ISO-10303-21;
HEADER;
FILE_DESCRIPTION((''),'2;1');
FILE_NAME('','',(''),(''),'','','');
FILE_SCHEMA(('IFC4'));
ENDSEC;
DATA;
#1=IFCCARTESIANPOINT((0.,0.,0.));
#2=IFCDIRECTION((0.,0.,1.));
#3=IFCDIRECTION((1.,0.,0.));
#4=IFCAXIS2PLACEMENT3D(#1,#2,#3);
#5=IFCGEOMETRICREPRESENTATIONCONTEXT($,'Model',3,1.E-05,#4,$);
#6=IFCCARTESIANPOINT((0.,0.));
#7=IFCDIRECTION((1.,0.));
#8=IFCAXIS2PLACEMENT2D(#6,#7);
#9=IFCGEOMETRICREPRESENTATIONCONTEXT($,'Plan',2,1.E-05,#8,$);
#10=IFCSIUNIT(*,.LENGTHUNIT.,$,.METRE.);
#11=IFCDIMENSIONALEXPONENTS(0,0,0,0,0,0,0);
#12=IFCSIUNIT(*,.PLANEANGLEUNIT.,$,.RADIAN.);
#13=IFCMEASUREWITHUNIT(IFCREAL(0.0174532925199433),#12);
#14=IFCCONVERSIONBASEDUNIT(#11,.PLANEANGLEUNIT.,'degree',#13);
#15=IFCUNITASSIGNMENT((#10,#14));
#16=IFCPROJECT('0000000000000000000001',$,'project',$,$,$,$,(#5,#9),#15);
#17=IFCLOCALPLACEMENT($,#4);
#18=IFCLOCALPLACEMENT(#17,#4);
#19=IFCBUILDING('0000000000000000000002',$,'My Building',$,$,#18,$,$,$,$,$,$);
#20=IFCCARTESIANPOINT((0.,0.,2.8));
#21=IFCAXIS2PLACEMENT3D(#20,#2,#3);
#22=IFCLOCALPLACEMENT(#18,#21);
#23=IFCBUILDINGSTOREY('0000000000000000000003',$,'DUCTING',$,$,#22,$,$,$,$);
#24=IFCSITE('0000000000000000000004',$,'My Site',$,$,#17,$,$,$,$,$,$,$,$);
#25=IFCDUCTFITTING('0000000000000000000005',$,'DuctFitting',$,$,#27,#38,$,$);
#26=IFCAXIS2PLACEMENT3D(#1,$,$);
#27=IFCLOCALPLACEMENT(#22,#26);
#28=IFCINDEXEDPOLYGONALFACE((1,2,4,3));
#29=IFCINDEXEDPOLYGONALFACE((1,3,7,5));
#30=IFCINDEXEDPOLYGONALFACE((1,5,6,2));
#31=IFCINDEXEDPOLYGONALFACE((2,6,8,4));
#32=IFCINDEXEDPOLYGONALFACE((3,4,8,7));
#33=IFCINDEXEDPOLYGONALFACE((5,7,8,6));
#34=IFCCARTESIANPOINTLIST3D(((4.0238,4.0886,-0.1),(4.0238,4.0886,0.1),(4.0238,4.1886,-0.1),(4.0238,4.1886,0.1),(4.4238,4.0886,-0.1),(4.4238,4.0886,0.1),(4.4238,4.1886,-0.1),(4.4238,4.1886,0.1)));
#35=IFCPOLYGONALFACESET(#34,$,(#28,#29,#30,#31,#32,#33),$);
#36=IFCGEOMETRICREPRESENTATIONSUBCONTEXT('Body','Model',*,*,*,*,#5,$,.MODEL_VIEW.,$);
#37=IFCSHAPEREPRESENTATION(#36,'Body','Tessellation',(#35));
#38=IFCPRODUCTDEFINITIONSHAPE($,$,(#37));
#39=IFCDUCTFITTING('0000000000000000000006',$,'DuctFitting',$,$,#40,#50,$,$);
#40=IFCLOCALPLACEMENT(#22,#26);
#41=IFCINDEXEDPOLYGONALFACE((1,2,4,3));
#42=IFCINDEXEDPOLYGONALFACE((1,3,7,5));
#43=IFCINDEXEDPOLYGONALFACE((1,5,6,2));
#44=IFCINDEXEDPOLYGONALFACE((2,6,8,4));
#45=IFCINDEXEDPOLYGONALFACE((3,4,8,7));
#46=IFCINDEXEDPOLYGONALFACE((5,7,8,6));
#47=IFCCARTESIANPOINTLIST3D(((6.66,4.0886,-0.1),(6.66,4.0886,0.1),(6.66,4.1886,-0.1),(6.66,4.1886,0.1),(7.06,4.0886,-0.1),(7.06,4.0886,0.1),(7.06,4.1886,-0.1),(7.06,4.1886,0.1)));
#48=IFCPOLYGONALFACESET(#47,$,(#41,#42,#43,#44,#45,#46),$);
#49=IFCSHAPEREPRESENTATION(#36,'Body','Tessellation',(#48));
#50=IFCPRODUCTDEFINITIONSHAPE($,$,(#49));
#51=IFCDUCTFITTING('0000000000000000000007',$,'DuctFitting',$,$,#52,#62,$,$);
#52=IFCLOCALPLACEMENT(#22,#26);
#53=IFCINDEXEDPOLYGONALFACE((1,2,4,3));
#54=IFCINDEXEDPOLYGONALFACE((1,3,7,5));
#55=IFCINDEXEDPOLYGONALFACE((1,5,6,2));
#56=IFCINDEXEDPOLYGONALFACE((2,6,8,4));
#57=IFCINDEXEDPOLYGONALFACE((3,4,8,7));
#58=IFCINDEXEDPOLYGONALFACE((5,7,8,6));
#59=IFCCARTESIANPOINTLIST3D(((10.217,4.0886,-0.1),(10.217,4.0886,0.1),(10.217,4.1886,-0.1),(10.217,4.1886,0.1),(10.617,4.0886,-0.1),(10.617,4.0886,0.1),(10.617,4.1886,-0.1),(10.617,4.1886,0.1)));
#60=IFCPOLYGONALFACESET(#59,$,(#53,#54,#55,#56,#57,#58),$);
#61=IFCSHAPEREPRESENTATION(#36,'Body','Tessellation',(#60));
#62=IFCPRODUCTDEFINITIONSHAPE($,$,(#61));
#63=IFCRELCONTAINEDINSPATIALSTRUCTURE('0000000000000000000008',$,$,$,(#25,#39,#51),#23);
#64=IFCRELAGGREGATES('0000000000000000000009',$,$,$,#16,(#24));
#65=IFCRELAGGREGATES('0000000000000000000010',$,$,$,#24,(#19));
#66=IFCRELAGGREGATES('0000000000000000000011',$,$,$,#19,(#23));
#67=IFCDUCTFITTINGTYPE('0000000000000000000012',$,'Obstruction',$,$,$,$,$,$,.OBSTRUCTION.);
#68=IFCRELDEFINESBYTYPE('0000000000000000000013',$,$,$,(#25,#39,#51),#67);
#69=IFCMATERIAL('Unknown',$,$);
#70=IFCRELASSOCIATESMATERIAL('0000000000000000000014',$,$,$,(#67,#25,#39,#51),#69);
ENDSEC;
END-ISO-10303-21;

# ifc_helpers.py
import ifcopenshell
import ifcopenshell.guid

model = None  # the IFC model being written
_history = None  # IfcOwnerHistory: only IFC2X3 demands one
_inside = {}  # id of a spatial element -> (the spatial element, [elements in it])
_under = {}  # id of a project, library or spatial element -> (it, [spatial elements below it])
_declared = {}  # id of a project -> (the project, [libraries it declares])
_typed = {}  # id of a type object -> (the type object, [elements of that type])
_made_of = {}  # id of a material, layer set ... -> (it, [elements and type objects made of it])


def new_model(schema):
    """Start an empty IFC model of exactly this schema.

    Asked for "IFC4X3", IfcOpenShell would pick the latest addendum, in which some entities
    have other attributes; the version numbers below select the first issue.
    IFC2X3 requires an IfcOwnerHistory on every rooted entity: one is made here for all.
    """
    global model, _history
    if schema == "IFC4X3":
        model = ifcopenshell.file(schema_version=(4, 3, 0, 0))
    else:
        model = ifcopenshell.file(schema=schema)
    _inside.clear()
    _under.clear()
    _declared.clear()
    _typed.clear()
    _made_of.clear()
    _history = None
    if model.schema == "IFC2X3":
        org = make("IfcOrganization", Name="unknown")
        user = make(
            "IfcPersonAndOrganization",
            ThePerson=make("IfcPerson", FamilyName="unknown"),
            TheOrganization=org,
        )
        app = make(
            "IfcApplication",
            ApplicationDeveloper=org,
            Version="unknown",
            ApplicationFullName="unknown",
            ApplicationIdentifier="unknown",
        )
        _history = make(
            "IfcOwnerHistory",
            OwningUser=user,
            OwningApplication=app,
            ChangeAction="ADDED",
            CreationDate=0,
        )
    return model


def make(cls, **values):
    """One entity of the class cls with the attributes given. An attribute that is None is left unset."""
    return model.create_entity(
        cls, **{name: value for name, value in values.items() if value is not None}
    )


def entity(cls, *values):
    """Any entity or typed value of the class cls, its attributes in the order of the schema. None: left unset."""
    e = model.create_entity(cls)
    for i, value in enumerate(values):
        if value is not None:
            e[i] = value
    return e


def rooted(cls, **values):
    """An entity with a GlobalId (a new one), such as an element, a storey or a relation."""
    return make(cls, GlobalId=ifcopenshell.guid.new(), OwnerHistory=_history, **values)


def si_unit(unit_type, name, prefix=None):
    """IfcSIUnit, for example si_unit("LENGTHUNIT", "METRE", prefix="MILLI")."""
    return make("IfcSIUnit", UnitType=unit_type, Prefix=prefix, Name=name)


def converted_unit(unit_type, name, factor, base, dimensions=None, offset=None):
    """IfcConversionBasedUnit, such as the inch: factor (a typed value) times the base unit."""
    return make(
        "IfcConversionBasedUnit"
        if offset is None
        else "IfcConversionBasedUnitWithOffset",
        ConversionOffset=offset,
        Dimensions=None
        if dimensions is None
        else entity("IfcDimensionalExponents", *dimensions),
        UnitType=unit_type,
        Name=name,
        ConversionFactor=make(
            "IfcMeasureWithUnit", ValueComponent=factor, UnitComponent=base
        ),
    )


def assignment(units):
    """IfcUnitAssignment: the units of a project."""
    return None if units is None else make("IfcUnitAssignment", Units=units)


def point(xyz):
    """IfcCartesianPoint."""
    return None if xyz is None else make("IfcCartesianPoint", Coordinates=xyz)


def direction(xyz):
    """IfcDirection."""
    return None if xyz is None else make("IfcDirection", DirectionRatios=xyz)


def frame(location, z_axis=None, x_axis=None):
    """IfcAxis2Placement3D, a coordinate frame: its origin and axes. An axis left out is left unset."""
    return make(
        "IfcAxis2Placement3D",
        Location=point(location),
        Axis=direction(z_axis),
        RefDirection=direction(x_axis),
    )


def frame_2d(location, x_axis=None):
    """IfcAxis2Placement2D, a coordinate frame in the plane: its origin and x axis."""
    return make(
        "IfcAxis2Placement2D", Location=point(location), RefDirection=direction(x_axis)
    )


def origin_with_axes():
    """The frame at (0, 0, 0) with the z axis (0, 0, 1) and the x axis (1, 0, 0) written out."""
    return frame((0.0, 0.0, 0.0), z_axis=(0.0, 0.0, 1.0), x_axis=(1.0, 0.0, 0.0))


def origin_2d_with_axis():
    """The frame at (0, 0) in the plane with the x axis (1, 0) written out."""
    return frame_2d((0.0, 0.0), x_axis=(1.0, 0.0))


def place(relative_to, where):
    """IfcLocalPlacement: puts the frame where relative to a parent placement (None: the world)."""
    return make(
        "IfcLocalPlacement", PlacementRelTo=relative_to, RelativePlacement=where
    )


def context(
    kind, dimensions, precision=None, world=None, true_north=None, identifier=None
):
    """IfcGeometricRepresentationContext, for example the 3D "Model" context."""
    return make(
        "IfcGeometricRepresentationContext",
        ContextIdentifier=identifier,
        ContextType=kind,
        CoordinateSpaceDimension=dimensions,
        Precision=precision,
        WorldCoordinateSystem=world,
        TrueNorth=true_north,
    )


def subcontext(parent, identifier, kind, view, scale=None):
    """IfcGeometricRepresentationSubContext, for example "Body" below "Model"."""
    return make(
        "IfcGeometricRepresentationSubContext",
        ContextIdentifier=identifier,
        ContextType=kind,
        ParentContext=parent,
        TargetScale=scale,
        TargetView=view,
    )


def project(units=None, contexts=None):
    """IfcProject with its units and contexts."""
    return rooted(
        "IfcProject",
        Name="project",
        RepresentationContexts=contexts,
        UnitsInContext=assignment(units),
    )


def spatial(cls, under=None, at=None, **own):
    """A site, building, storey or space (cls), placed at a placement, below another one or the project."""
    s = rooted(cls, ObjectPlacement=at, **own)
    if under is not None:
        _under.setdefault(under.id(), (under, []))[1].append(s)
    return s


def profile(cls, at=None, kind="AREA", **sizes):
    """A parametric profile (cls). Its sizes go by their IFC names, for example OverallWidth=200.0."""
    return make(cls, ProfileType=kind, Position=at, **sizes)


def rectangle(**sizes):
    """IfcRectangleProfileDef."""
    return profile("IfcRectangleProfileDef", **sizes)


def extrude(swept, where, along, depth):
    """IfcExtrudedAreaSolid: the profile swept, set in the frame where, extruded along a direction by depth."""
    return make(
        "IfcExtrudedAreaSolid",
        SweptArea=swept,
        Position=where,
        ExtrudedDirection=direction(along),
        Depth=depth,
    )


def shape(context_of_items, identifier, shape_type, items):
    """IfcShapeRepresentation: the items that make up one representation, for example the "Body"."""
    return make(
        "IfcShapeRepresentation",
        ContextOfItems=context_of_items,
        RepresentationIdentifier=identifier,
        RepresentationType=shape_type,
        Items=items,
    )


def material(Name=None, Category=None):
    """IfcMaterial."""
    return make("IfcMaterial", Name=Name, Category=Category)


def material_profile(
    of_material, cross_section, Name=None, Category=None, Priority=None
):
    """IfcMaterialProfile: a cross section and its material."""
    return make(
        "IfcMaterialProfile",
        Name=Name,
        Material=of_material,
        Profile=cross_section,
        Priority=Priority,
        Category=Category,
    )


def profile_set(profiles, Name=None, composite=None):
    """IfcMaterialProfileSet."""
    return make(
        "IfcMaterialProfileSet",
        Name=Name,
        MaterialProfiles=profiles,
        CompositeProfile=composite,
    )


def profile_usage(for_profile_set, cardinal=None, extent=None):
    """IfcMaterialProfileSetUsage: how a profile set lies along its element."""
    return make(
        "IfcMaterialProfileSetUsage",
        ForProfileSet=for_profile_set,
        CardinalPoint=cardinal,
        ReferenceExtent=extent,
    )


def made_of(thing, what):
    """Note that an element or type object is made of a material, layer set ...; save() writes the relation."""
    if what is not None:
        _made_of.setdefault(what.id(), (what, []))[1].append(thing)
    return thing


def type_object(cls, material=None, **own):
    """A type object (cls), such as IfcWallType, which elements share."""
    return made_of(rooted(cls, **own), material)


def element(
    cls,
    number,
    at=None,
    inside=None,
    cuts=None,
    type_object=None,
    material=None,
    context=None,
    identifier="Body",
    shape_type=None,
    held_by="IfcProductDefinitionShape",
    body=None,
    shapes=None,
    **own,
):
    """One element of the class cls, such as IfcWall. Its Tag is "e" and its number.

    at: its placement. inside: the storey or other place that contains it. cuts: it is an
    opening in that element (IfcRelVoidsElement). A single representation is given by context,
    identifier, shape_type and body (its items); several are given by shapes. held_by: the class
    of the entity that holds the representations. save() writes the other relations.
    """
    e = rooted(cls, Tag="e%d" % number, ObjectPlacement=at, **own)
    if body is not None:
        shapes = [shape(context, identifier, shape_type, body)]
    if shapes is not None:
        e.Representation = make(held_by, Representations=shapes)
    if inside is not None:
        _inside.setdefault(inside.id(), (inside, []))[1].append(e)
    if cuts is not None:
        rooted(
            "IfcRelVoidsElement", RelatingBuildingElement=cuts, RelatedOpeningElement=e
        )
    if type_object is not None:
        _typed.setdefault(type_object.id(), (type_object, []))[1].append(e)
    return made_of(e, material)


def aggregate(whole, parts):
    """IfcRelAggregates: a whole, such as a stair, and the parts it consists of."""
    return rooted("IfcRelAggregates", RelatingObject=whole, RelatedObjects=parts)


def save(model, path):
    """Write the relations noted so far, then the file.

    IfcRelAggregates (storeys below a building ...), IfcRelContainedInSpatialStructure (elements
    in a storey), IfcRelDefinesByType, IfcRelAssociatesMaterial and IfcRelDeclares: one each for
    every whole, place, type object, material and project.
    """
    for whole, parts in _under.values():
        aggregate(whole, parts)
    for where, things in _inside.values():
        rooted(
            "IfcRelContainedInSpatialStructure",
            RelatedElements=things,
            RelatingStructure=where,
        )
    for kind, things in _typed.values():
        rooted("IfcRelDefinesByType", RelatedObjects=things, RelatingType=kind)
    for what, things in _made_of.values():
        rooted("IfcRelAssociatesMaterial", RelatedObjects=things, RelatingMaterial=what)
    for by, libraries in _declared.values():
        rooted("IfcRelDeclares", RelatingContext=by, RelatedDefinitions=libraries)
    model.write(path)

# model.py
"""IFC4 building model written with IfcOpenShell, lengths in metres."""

from ifc_helpers import new_model, entity, si_unit, converted_unit, frame, origin_with_axes, origin_2d_with_axis, place, context, subcontext, project, spatial, rectangle, extrude, material, material_profile, profile_set, profile_usage, type_object, element, save


model = new_model("IFC4")

# Units and contexts
model_context = context("Model", 3, precision=1e-05, world=origin_with_axes())
plan_context = context("Plan", 2, precision=1e-05, world=origin_2d_with_axis())
body_context = subcontext(model_context, "Body", "Model", "MODEL_VIEW")
ifc_project = project(units=[si_unit("LENGTHUNIT", "METRE"), converted_unit("PLANEANGLEUNIT", "degree", entity("IfcReal", 0.0174532925199433), si_unit("PLANEANGLEUNIT", "RADIAN"), dimensions=[0, 0, 0, 0, 0, 0, 0])], contexts=[model_context, plan_context])

# Site, building, storey
site_placement = place(None, origin_with_axes())
site = spatial("IfcSite", under=ifc_project, at=site_placement, Name="My Site")
building_placement = place(site_placement, origin_with_axes())
building = spatial("IfcBuilding", under=site, at=building_placement, Name="My Building")
storey_placement = place(building_placement, frame((0.0, 0.0, 2.8), z_axis=(0.0, 0.0, 1.0), x_axis=(1.0, 0.0, 0.0)))
storey = spatial("IfcBuildingStorey", under=building, at=storey_placement, Name="DUCTING")

# Shared definitions
ifc_material = material(Name="Unknown")

# Duct fittings
ifc_material_profile_1 = material_profile(ifc_material, rectangle(XDim=0.4, YDim=0.2))
ifc_profile_set_1 = profile_set([ifc_material_profile_1])
duct_fitting_type_1 = type_object("IfcDuctFittingType", Name="Obstruction", PredefinedType="OBSTRUCTION", material=ifc_profile_set_1)
ifc_profile_usage_1 = profile_usage(ifc_profile_set_1, cardinal=5)
duct_fitting_1_placement = place(storey_placement, frame((4.2238, 4.1886, 0.0), z_axis=(0.0, -1.0, 0.0), x_axis=(-1.0, 0.0, 0.0)))
element("IfcDuctFitting", 1, at=duct_fitting_1_placement, inside=storey, type_object=duct_fitting_type_1, material=ifc_profile_usage_1, Name="DuctFitting", context=body_context, shape_type="SweptSolid", body=[
    extrude(rectangle(XDim=0.4, YDim=0.2), origin_with_axes(), (0.0, 0.0, 1.0), 0.1),
])
ifc_profile_usage_2 = profile_usage(ifc_profile_set_1, cardinal=5)
duct_fitting_2_placement = place(storey_placement, frame((6.86, 4.1886, 0.0), z_axis=(0.0, -1.0, 0.0), x_axis=(-1.0, 0.0, 0.0)))
element("IfcDuctFitting", 2, at=duct_fitting_2_placement, inside=storey, type_object=duct_fitting_type_1, material=ifc_profile_usage_2, Name="DuctFitting", context=body_context, shape_type="SweptSolid", body=[
    extrude(rectangle(XDim=0.4, YDim=0.2), origin_with_axes(), (0.0, 0.0, 1.0), 0.1),
])
ifc_profile_usage_3 = profile_usage(ifc_profile_set_1, cardinal=5)
duct_fitting_3_placement = place(storey_placement, frame((10.417, 4.1886, 0.0), z_axis=(0.0, -1.0, 0.0), x_axis=(-1.0, 0.0, 0.0)))
element("IfcDuctFitting", 3, at=duct_fitting_3_placement, inside=storey, type_object=duct_fitting_type_1, material=ifc_profile_usage_3, Name="DuctFitting", context=body_context, shape_type="SweptSolid", body=[
    extrude(rectangle(XDim=0.4, YDim=0.2), origin_with_axes(), (0.0, 0.0, 1.0), 0.1),
])

save(model, "model.ifc")
